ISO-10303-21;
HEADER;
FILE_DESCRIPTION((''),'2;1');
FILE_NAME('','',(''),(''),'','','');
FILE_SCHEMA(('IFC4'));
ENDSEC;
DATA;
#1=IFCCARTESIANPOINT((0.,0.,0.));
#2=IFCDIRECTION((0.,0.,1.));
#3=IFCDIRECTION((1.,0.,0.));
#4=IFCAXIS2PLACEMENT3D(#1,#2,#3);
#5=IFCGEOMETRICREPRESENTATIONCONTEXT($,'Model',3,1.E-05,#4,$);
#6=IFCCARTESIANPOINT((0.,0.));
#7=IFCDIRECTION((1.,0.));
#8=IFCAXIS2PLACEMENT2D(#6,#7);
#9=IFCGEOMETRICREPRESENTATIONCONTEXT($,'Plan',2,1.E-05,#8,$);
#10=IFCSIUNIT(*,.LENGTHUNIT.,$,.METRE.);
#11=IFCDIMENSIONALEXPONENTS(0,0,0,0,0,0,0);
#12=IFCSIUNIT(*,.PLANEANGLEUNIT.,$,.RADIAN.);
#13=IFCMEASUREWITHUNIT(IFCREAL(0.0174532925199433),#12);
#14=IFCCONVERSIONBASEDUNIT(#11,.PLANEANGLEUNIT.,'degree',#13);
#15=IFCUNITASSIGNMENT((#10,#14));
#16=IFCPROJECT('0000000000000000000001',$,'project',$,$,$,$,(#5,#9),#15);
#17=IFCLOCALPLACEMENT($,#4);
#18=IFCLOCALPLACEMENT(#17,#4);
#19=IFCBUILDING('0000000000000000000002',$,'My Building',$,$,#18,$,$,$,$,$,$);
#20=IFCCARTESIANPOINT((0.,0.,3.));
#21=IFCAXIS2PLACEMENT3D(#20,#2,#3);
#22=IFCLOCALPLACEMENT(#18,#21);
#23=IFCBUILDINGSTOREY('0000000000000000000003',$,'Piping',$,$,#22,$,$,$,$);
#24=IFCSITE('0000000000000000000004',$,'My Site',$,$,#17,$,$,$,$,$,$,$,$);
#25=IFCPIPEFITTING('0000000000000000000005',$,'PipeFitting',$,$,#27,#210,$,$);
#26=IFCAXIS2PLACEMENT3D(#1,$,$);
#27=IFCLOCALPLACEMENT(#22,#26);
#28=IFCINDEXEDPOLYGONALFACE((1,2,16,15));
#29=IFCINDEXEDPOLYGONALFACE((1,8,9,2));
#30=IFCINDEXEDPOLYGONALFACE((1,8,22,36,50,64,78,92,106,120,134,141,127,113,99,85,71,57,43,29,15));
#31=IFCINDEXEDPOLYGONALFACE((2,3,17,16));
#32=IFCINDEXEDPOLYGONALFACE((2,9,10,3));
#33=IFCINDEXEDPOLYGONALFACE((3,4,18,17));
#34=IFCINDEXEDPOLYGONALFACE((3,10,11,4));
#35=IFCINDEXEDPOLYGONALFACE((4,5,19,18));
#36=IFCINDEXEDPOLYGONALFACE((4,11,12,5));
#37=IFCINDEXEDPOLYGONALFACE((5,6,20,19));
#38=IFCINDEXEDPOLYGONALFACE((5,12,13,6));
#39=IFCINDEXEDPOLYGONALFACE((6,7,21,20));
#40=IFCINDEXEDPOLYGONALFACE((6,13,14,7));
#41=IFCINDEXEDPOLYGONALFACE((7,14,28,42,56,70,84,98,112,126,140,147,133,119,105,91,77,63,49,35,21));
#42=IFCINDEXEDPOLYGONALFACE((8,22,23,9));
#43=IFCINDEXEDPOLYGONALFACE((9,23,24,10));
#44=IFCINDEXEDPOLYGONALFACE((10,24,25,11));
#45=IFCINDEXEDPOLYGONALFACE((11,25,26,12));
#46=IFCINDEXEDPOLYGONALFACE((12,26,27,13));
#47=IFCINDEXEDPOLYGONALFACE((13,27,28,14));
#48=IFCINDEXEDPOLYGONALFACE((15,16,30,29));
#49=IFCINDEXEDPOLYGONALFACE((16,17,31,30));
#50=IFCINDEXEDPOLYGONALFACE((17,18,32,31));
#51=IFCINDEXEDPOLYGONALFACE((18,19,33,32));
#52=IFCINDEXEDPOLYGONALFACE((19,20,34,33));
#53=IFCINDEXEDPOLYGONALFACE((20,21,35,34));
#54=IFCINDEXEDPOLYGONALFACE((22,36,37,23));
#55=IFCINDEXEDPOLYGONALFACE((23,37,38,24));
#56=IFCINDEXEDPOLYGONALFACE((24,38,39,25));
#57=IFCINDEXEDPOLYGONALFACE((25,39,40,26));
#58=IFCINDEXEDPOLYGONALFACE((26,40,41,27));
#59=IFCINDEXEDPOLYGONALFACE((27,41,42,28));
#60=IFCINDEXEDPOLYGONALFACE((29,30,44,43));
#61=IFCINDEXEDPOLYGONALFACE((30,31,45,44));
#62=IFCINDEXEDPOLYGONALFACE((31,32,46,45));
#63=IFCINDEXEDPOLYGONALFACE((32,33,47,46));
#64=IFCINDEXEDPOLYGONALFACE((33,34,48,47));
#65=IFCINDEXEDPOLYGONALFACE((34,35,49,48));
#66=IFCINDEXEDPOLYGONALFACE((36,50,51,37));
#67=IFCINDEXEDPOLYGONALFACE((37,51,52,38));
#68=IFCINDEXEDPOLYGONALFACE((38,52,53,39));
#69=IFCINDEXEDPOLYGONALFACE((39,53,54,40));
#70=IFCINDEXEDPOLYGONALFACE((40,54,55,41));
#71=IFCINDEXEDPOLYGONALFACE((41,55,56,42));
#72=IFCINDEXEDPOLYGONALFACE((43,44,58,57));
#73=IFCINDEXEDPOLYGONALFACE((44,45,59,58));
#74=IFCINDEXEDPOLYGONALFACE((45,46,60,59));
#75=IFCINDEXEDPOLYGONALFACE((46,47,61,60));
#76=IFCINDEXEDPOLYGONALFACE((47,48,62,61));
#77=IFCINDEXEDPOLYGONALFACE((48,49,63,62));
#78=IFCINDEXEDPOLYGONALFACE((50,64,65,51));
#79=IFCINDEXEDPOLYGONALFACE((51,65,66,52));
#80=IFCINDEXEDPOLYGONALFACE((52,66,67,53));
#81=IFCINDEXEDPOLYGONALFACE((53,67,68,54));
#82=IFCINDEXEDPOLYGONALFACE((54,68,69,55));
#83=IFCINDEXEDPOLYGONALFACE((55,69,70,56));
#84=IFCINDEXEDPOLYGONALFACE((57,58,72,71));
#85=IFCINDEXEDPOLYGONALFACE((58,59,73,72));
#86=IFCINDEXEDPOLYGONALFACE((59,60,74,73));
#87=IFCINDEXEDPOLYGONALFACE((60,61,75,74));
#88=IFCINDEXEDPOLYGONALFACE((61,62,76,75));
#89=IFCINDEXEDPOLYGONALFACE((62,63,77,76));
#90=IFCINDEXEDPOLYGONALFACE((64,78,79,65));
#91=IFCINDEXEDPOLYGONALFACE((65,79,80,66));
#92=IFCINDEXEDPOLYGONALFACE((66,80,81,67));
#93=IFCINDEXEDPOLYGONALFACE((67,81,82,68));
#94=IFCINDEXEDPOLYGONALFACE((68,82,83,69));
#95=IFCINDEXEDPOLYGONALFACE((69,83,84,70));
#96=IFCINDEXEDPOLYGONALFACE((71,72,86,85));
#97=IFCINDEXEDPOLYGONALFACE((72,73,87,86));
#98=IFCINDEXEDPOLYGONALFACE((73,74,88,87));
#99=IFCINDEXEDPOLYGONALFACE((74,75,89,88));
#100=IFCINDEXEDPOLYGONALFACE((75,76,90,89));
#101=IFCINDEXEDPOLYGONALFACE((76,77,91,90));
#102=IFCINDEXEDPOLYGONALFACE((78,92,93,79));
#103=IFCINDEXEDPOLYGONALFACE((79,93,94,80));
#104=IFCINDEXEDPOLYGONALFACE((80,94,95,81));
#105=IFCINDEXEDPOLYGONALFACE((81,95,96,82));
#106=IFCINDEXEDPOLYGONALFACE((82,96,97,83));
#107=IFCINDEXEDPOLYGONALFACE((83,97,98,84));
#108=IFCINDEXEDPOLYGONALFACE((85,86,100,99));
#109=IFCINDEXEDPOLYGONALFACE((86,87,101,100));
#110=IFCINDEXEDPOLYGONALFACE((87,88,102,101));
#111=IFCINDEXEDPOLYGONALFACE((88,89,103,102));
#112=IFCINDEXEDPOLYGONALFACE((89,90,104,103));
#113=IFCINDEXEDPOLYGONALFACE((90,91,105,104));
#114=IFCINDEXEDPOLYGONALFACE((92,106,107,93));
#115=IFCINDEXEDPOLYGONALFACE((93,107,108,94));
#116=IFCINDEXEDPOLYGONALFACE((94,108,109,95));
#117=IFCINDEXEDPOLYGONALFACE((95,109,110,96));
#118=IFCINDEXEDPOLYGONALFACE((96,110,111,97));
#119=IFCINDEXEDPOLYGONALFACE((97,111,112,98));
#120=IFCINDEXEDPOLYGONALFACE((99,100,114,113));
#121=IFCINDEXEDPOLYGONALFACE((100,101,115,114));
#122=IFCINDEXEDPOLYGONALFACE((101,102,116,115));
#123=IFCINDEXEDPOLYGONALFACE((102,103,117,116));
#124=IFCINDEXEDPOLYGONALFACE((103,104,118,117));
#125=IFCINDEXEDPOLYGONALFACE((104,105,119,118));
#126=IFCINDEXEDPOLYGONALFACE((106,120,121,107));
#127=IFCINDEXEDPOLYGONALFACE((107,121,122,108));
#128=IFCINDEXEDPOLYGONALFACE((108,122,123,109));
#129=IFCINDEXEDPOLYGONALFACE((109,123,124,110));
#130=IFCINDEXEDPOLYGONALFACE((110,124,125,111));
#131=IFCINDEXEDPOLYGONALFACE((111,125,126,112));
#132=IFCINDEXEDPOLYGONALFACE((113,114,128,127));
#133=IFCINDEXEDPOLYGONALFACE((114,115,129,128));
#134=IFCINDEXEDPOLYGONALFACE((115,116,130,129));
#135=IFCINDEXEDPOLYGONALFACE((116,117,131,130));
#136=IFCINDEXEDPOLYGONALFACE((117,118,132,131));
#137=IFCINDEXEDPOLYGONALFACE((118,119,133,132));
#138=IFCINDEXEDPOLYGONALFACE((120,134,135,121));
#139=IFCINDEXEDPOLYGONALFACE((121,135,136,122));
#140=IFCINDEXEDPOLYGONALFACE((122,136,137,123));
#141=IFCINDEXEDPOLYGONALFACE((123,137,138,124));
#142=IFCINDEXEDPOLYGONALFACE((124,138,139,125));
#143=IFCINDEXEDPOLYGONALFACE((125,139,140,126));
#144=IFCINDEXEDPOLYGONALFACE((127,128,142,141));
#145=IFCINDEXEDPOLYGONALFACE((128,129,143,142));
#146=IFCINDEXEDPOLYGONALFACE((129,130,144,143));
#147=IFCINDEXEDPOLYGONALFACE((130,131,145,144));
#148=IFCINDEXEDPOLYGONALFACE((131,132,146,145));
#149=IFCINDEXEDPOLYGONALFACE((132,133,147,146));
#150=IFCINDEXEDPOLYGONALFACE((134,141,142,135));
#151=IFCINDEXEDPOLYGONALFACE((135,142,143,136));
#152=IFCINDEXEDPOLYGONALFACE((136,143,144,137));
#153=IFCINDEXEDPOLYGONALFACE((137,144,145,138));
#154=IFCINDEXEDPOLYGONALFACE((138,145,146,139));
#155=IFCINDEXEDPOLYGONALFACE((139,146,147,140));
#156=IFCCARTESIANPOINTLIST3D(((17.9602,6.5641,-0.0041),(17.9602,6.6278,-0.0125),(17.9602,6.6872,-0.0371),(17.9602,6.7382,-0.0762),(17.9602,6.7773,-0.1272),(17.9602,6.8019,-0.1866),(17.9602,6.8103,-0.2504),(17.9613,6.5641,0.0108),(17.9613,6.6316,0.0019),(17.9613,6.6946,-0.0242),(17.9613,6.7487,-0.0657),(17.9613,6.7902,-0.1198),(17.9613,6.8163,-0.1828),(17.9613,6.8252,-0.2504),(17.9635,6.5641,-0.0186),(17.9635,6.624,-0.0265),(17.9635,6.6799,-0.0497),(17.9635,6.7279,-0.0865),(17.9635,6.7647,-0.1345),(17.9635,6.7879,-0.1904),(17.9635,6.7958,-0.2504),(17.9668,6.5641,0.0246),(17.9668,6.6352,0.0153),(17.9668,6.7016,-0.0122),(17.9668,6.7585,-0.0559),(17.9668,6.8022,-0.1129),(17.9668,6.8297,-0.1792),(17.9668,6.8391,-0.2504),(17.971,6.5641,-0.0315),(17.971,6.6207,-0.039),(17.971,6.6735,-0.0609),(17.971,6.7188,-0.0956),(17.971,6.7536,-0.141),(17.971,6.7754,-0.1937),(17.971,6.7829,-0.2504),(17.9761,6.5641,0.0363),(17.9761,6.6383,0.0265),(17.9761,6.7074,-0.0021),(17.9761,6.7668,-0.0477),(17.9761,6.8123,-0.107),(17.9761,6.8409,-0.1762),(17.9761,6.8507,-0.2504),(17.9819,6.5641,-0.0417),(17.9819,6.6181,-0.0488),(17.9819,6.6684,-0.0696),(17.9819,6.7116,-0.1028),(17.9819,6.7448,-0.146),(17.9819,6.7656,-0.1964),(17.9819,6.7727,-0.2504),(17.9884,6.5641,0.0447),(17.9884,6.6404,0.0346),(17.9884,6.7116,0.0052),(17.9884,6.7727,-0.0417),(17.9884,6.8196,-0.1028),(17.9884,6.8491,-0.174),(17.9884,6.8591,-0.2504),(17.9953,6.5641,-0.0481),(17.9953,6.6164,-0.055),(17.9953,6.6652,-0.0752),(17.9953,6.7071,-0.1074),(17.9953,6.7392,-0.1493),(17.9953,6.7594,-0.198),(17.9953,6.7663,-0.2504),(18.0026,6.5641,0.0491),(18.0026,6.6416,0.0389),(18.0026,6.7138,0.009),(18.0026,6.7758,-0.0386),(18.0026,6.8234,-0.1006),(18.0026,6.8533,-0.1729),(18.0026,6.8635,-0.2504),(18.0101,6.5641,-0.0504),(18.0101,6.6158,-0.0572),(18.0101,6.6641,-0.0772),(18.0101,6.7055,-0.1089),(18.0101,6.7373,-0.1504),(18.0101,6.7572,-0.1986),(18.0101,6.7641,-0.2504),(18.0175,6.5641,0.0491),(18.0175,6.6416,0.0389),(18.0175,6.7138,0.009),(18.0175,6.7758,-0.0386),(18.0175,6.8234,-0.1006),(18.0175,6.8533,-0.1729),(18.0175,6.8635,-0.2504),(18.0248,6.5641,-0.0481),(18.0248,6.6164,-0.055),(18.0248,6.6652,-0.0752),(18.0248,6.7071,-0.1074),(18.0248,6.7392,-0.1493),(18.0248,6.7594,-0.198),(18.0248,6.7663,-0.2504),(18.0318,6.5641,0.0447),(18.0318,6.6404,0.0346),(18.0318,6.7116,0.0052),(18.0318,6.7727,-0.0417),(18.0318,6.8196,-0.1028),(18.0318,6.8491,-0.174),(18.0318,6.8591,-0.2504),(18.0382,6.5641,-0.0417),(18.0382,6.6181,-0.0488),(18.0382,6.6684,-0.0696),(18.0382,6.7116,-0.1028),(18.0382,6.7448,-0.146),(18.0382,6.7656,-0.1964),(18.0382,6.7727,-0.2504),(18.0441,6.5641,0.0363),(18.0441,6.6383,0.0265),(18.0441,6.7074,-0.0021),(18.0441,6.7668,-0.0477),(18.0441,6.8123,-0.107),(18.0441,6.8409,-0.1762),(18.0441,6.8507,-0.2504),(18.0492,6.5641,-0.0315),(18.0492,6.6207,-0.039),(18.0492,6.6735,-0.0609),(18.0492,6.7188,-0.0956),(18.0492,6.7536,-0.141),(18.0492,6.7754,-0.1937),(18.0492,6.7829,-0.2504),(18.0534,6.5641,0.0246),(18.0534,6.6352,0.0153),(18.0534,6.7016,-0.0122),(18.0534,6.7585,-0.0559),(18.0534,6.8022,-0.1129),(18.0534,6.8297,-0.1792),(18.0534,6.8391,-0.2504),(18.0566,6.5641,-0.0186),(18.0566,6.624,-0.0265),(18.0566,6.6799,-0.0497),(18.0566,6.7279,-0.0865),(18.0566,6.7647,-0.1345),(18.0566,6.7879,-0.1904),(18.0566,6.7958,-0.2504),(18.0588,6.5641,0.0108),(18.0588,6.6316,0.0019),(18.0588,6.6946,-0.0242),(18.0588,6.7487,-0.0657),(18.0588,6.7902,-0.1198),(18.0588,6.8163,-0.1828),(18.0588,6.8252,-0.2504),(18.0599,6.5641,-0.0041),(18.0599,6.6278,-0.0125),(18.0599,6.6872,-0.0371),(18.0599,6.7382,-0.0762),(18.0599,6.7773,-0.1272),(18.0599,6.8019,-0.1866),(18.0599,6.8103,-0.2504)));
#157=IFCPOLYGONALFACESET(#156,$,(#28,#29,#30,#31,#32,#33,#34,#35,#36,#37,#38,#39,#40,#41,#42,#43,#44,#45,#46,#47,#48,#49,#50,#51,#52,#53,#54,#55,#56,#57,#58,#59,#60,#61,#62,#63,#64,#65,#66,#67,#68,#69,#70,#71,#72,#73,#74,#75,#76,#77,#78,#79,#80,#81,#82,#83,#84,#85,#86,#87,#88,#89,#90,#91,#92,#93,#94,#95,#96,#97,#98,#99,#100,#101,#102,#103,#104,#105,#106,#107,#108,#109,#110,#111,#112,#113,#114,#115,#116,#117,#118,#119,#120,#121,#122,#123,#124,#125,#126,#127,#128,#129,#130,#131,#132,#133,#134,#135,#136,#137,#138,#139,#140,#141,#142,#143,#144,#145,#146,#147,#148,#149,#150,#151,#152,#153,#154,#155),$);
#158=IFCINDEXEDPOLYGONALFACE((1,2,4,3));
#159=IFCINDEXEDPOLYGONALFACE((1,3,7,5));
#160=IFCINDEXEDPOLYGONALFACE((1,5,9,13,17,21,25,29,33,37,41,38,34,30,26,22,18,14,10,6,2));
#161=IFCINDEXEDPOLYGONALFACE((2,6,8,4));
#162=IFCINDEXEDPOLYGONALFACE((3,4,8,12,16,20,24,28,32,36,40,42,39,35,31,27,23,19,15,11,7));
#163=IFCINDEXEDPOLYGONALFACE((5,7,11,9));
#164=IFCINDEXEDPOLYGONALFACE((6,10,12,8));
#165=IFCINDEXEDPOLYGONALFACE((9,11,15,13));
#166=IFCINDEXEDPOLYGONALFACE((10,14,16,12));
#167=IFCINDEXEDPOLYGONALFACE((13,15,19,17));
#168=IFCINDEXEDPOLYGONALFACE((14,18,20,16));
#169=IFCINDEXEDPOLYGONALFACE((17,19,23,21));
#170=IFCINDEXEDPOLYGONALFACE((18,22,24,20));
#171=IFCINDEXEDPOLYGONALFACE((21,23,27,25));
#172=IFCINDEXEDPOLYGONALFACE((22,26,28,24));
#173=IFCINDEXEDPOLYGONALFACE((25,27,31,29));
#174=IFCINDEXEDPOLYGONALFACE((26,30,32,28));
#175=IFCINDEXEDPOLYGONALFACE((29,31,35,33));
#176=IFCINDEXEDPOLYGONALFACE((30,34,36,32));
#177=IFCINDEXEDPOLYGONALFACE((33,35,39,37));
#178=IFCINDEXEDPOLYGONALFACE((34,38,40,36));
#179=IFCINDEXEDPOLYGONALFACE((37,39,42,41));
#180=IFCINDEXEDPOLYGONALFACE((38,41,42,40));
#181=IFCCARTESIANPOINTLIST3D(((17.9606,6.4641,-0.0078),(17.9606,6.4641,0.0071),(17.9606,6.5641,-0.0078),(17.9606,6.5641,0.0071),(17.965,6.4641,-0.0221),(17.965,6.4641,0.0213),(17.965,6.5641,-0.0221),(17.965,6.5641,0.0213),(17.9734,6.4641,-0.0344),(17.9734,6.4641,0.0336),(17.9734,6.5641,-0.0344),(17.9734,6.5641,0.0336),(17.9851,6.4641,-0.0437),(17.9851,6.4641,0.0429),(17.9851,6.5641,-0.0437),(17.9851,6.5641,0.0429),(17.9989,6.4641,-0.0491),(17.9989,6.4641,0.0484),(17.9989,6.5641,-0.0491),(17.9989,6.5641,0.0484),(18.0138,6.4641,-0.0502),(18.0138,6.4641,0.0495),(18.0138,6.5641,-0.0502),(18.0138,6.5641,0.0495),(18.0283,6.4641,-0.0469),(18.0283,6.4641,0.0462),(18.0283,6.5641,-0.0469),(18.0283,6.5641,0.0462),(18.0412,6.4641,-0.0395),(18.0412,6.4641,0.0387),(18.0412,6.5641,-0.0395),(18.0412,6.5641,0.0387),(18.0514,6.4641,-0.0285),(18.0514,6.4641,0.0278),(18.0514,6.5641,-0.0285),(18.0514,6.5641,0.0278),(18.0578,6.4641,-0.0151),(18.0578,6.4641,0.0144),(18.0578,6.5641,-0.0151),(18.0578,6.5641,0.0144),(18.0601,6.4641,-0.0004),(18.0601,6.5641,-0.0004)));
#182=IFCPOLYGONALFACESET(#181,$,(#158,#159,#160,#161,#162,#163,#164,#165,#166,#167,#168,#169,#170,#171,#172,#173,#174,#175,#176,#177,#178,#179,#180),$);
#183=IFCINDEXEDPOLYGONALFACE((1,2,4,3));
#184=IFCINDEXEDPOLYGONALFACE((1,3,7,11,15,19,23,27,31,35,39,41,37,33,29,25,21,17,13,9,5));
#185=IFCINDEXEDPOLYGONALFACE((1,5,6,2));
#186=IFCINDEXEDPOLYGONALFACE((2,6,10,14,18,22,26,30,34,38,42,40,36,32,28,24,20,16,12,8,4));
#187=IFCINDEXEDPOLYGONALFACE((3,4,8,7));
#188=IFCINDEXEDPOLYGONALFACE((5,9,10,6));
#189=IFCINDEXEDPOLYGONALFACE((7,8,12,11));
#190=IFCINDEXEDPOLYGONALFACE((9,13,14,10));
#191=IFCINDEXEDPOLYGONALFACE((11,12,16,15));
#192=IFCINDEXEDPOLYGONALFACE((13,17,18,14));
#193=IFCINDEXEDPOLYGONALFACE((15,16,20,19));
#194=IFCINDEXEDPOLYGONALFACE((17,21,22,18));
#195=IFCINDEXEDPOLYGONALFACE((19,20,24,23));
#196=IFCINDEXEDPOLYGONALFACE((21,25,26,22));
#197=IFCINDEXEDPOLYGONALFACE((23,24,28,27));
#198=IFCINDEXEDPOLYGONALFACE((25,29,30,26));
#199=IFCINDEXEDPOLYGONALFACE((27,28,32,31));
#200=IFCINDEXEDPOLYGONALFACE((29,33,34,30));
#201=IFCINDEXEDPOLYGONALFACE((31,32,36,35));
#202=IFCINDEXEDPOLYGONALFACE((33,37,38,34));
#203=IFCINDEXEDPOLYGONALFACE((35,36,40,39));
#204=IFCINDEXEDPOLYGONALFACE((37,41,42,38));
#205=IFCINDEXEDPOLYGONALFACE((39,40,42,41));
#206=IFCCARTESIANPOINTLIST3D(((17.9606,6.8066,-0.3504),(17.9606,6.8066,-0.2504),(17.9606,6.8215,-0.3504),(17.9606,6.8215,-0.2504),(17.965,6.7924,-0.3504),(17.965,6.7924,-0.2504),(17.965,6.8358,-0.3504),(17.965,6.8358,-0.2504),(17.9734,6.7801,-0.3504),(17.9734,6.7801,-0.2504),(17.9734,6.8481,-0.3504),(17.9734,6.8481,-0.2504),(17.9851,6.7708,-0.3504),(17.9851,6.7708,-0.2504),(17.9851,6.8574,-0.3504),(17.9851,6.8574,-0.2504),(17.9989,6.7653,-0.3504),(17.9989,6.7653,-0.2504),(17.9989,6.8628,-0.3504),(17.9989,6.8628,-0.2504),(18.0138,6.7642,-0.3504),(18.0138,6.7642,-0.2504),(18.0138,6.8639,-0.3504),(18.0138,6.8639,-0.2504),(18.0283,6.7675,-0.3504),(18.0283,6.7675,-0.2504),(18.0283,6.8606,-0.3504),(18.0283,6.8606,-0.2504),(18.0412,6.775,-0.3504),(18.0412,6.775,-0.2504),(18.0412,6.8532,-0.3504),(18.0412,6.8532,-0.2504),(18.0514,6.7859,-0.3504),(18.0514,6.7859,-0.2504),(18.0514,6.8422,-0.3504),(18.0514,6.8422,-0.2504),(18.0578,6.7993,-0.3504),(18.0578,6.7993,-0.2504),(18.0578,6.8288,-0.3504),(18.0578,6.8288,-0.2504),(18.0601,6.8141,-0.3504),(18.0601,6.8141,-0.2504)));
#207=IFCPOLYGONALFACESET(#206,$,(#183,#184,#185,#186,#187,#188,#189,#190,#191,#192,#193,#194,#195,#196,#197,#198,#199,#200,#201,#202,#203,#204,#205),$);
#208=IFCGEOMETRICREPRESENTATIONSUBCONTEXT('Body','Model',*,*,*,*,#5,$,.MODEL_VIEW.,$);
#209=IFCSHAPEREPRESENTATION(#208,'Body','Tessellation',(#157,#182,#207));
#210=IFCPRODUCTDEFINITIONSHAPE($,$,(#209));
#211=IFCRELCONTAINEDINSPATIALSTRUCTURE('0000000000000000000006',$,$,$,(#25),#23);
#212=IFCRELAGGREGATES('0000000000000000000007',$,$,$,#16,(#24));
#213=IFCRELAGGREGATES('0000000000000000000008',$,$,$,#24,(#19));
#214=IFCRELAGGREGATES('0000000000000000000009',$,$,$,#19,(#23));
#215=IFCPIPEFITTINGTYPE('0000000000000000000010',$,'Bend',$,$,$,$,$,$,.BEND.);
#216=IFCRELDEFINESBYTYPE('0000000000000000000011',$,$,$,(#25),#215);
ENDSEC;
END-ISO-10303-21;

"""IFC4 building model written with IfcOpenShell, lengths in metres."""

from ifc_helpers import new_model, entity, si_unit, converted_unit, frame, origin_with_axes, origin_2d_with_axis, place, context, subcontext, project, spatial, circle, extrude, source, transform, mapped, type_object, type_shapes, element, save


model = new_model("IFC4")

# Units and contexts
model_context = context("Model", 3, precision=1e-05, world=origin_with_axes())
plan_context = context("Plan", 2, precision=1e-05, world=origin_2d_with_axis())
body_context = subcontext(model_context, "Body", "Model", "MODEL_VIEW")
ifc_project = project(units=[si_unit("LENGTHUNIT", "METRE"), converted_unit("PLANEANGLEUNIT", "degree", entity("IfcReal", 0.0174532925199433), si_unit("PLANEANGLEUNIT", "RADIAN"), dimensions=[0, 0, 0, 0, 0, 0, 0])], contexts=[model_context, plan_context])

# Site, building, storey
site_placement = place(None, origin_with_axes())
site = spatial("IfcSite", under=ifc_project, at=site_placement, Name="My Site")
building_placement = place(site_placement, origin_with_axes())
building = spatial("IfcBuilding", under=site, at=building_placement, Name="My Building")
storey_placement = place(building_placement, frame((0.0, 0.0, 3.0), z_axis=(0.0, 0.0, 1.0), x_axis=(1.0, 0.0, 0.0)))
storey = spatial("IfcBuildingStorey", under=building, at=storey_placement, Name="Piping")

# Shared definitions
pipe_fitting_type = type_object("IfcPipeFittingType", Name="Bend", PredefinedType="BEND")
shared_shape = source(origin_with_axes(), body_context, "Body", "SolidModel", [
    entity("IfcSweptDiskSolid", entity("IfcIndexedPolyCurve", entity("IfcCartesianPointList3D", [[0.0, 0.0, -0.1], [0.0, -0.0732, -0.2768], [0.0, -0.25, -0.35]]), [entity("IfcArcIndex", [1, 2, 3])]), 0.05),
    extrude(circle(Radius=0.05), origin_with_axes(), (0.0, 0.0, -1.0), 0.1),
    extrude(circle(Radius=0.05), frame((0.0, -0.25, -0.35), z_axis=(0.0, -1.0, 0.0), x_axis=(1.0, 0.0, 0.0)), (0.0, 0.0, 1.0), 0.1),
])
type_shapes(pipe_fitting_type, [shared_shape])

# Pipe fitting
for number, where, z_axis, x_axis, name in (
    (1, (18.0101, 6.4641, -0.0004), (0.0, -1.0, 0.0), (1.0, 0.0, 0.0), "PipeFitting"),
):
    element("IfcPipeFitting", number, at=place(storey_placement, frame(where, z_axis=z_axis, x_axis=x_axis)), inside=storey, type_object=pipe_fitting_type, Name=name, context=body_context, shape_type="MappedRepresentation", body=[
        mapped(shared_shape, transform((0.0, 0.0, 0.0), x_axis=(1.0, 0.0, 0.0), y_axis=(0.0, 1.0, 0.0), z_axis=(0.0, 0.0, 1.0), scale=1.0)),
    ])

save(model, "model.ifc")
